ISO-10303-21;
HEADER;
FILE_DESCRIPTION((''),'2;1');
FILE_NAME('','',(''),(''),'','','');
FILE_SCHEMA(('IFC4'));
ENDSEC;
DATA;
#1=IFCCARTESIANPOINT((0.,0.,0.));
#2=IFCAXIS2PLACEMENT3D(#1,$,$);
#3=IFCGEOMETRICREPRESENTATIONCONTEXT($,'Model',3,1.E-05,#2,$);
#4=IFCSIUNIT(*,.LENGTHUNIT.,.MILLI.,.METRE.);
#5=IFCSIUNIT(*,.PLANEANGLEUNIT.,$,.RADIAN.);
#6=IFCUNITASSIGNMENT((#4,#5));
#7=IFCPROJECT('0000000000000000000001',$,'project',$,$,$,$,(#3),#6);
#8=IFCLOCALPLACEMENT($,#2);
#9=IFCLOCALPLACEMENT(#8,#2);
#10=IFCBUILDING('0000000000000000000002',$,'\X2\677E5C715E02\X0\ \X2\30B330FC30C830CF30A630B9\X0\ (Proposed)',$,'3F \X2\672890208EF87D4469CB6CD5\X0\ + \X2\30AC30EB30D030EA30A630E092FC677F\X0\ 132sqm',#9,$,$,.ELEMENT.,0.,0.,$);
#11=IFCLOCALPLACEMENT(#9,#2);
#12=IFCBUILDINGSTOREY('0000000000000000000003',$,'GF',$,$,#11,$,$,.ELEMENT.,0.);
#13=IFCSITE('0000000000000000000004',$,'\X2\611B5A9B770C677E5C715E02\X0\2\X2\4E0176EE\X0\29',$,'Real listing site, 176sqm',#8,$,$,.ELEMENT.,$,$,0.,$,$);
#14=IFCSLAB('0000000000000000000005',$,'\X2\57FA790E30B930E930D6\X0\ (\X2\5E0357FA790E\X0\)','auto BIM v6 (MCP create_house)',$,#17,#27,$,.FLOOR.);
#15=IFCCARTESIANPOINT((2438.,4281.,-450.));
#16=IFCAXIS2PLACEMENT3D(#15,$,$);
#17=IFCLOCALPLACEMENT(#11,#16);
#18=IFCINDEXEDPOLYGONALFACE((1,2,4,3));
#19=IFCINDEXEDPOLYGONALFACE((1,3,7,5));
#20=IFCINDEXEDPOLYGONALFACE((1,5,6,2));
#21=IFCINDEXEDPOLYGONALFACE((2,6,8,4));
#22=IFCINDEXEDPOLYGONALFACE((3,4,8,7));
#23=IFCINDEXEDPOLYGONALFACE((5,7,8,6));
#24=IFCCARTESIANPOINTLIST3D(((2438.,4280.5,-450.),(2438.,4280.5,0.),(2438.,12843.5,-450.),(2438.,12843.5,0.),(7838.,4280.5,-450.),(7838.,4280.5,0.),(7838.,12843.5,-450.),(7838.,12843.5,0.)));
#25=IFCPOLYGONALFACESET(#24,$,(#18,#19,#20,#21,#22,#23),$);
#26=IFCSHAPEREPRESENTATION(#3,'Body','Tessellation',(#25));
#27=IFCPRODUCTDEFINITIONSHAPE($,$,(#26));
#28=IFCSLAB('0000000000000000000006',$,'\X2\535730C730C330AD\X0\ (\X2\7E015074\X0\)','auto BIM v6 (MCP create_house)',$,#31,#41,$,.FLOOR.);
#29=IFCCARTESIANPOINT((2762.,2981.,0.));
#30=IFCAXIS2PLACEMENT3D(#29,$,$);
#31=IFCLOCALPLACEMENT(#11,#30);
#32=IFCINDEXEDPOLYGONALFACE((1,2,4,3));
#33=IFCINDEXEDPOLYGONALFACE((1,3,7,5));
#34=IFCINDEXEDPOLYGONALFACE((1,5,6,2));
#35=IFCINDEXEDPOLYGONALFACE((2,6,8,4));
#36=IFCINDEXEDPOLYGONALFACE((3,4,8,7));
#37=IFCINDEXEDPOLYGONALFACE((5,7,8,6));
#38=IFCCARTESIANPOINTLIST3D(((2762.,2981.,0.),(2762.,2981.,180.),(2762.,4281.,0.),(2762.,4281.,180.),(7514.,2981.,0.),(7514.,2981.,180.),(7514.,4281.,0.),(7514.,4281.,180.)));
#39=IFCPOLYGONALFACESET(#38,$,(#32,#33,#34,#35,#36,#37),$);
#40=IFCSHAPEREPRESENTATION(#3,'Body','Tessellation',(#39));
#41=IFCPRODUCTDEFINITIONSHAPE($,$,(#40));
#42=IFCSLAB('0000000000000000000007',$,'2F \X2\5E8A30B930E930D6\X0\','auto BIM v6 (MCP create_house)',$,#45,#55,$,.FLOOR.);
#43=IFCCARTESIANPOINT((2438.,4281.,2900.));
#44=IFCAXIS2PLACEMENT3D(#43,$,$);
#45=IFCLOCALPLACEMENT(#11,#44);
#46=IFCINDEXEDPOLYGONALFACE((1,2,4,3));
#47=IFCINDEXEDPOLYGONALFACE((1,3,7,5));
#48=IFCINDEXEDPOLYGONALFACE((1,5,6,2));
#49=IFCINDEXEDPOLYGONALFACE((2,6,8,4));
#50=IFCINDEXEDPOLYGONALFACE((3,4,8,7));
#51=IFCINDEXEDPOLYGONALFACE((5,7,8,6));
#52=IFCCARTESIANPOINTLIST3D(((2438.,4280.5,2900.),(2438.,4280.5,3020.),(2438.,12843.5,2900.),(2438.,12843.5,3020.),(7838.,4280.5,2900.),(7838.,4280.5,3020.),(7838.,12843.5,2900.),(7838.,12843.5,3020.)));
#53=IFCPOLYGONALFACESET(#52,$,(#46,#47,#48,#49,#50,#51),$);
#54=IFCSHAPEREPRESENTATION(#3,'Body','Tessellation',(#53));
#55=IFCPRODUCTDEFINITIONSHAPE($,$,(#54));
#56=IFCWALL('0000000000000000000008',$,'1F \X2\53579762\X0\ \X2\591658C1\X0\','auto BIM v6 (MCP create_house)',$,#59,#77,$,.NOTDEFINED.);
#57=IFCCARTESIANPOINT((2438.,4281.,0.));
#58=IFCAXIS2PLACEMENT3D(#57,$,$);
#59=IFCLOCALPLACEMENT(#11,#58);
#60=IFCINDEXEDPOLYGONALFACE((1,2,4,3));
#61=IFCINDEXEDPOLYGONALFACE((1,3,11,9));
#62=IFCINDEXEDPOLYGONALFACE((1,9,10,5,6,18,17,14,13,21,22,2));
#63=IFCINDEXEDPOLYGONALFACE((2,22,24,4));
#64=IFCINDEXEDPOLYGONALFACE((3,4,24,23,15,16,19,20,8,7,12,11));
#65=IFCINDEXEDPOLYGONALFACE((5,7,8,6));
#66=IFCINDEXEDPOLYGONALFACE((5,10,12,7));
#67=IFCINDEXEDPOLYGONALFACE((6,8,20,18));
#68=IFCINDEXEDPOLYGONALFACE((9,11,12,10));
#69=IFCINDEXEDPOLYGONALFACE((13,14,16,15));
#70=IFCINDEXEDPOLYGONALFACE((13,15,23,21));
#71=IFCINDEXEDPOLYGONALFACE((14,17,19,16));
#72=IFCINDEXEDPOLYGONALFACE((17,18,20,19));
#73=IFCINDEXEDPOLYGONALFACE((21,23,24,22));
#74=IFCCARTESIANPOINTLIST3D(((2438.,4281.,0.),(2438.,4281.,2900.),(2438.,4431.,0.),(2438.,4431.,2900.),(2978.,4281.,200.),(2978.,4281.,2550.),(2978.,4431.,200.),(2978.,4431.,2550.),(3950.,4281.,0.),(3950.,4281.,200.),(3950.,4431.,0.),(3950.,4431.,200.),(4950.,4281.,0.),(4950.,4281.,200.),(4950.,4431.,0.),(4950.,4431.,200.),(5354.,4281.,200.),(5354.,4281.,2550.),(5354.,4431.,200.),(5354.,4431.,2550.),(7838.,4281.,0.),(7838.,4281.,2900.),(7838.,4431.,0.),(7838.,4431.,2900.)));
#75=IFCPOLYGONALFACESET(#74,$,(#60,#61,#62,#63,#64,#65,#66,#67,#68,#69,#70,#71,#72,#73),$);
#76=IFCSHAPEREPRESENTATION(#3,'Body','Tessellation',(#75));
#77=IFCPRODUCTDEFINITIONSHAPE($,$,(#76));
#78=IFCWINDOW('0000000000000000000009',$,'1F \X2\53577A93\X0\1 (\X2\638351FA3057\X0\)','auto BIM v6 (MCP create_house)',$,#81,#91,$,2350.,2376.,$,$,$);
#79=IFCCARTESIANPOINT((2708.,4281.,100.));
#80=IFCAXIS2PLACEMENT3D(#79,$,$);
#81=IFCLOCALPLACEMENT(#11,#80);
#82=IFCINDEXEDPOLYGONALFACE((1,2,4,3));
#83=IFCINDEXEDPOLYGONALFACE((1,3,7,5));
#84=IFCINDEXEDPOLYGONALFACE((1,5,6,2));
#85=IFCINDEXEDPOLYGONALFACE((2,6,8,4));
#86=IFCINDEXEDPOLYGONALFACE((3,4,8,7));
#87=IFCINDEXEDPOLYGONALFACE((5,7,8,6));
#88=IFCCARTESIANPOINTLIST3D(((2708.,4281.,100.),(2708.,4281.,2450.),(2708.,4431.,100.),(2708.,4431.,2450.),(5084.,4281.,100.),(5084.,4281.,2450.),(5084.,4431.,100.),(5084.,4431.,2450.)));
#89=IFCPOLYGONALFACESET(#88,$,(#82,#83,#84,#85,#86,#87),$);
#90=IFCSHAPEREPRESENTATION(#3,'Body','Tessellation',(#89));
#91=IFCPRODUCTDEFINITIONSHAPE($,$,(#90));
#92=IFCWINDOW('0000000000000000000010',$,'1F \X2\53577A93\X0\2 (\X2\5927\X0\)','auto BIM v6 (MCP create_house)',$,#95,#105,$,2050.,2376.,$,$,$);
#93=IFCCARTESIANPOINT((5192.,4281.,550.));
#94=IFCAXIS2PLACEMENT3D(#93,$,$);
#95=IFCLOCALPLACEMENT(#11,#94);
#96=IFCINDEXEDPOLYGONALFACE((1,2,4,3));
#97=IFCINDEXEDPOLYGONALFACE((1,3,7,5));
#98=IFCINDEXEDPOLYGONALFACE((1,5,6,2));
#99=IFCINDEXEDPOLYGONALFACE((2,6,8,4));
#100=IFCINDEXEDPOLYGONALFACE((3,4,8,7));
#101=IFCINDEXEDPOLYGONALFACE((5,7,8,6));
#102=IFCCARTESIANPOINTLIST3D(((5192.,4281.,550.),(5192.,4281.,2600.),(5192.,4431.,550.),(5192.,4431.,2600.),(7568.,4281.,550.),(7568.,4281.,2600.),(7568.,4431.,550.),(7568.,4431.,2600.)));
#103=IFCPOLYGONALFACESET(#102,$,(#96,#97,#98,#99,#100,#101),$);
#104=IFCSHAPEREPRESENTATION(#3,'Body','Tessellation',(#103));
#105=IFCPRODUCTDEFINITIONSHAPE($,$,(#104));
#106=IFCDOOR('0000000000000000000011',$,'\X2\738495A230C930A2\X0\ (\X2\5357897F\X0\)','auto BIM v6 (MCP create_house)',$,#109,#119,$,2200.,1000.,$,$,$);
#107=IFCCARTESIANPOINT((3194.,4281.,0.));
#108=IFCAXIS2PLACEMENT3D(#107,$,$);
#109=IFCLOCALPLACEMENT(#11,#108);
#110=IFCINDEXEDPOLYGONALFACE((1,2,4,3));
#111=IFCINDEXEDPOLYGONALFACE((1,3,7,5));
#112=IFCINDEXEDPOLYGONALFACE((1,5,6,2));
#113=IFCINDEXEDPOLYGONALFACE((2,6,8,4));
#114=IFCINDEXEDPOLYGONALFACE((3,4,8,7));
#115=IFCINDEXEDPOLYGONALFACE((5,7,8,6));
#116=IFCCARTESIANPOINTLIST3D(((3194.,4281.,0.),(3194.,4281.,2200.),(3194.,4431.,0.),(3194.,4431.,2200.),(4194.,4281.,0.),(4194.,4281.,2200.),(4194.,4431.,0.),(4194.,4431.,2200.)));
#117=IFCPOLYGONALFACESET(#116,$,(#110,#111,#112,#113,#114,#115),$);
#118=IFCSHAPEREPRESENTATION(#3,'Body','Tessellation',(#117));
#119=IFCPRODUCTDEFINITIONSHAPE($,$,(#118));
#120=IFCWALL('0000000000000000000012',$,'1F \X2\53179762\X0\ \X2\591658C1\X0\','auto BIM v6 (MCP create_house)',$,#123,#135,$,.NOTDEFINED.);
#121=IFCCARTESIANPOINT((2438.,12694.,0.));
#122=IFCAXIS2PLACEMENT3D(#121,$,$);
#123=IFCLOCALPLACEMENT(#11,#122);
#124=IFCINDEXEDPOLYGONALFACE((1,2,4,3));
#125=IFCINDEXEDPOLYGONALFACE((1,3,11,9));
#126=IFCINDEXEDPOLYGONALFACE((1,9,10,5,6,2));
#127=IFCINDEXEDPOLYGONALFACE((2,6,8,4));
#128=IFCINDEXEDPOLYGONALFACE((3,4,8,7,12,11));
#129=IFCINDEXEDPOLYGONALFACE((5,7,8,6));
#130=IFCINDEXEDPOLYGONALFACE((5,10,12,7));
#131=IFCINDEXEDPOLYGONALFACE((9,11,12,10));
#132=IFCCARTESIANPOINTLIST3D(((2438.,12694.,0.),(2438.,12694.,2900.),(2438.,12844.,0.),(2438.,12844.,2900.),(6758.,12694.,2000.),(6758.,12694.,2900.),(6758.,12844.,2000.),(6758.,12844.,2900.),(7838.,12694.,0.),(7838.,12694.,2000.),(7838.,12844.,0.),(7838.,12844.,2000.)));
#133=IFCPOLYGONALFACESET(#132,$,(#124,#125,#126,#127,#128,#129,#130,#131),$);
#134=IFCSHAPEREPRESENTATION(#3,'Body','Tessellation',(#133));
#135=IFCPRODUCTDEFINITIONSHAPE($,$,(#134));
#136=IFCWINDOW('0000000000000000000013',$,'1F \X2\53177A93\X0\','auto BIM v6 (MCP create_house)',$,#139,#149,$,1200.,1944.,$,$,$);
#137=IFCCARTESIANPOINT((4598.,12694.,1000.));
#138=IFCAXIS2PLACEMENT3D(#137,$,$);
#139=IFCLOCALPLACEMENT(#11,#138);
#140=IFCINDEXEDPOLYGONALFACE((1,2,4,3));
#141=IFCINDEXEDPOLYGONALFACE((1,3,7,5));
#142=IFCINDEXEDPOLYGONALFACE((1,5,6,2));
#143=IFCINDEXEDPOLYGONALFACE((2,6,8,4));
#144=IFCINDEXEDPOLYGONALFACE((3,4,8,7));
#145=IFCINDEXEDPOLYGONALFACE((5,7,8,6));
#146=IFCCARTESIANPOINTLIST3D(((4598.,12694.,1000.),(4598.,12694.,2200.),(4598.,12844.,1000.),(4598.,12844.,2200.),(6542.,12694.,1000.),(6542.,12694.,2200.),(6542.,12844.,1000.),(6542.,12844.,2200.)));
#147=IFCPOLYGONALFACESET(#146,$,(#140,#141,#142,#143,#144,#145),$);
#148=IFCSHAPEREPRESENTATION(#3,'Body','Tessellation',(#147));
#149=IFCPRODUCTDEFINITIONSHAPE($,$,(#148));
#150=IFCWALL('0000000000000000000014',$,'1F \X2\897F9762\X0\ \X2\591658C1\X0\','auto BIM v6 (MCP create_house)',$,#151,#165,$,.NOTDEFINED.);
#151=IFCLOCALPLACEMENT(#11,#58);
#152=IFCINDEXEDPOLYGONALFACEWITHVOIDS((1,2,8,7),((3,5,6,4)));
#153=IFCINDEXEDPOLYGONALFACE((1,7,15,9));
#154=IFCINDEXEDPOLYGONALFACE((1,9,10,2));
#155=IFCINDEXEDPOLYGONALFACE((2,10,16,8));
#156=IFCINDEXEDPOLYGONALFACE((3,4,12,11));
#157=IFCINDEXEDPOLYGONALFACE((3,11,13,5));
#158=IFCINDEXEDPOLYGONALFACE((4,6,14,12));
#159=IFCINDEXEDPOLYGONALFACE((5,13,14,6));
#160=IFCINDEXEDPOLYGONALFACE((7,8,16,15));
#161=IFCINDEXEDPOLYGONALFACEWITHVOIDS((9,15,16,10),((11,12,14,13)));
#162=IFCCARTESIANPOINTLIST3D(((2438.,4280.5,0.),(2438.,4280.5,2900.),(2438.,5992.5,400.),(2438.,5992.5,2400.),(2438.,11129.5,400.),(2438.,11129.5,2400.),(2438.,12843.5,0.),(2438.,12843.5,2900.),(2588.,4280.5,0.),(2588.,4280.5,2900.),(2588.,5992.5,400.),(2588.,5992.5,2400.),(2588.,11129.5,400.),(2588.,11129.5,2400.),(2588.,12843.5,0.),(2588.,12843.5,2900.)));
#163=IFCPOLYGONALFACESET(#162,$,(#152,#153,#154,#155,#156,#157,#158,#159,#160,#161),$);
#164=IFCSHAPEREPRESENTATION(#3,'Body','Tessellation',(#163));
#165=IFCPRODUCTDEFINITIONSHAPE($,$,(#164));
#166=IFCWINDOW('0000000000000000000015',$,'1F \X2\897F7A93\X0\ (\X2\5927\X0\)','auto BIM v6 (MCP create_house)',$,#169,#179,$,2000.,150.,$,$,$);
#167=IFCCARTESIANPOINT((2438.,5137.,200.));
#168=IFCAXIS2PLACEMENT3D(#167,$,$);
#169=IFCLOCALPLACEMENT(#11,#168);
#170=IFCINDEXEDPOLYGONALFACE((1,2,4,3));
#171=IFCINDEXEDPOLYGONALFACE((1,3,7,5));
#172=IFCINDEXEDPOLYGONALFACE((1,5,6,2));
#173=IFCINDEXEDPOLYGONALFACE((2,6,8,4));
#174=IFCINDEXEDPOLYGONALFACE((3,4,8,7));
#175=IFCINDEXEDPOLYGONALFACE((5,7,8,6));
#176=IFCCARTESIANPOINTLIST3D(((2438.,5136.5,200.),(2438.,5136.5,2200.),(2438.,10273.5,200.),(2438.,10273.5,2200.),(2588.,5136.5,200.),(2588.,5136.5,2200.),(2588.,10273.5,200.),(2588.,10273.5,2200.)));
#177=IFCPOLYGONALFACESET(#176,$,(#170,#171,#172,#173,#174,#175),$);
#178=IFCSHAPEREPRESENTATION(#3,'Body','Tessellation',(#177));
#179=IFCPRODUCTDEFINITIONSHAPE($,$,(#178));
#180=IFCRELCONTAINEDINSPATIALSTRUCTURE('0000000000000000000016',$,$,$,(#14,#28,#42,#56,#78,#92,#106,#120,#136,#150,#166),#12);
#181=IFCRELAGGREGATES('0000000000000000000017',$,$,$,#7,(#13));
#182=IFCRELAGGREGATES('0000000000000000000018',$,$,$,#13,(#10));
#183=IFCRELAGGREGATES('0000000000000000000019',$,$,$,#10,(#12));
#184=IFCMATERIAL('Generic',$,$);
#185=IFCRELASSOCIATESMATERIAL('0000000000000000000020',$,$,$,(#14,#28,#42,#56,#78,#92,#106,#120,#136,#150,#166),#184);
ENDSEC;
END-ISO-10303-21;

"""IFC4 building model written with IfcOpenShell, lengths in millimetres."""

from ifc_helpers import new_model, si_unit, frame, frame_2d, origin, place, context, project, spatial, rectangle, extrude, material, element, fill, save


model = new_model("IFC4")

# Units and contexts
model_context = context("Model", 3, precision=1e-05, world=origin())
ifc_project = project(units=[si_unit("LENGTHUNIT", "METRE", prefix="MILLI"), si_unit("PLANEANGLEUNIT", "RADIAN")], contexts=[model_context])

# Site, building, storey
site_placement = place(None, origin())
site = spatial("IfcSite", under=ifc_project, at=site_placement, Name="愛媛県松山市2丁目29", ObjectType="Real listing site, 176sqm", CompositionType="ELEMENT", RefElevation=0.0)
building_placement = place(site_placement, origin())
building = spatial("IfcBuilding", under=site, at=building_placement, Name="松山市 コートハウス (Proposed)", ObjectType="3F 木造軸組構法 + ガルバリウム鋼板 132sqm", CompositionType="ELEMENT", ElevationOfRefHeight=0.0, ElevationOfTerrain=0.0)
storey_placement = place(building_placement, origin())
storey = spatial("IfcBuildingStorey", under=building, at=storey_placement, Name="GF", CompositionType="ELEMENT", Elevation=0.0)

# Slabs
ifc_material = material(Name="Generic")
slab_1_placement = place(storey_placement, frame((2438.0, 4281.0, -450.0)))
element("IfcSlab", 1, at=slab_1_placement, inside=storey, material=ifc_material, Name="基礎スラブ (布基礎)", Description="auto BIM v6 (MCP create_house)", PredefinedType="FLOOR", context=model_context, shape_type="SweptSolid", body=[
    extrude(rectangle(XDim=5400.0, YDim=8563.0, at=frame_2d((2700.0, 4281.0))), frame((2438.0, 4281.0, -450.0)), (0.0, 0.0, 1.0), 450.0),
])
slab_2_placement = place(storey_placement, frame((2762.0, 2981.0, 0.0)))
element("IfcSlab", 2, at=slab_2_placement, inside=storey, material=ifc_material, Name="南デッキ (縁側)", Description="auto BIM v6 (MCP create_house)", PredefinedType="FLOOR", context=model_context, shape_type="SweptSolid", body=[
    extrude(rectangle(XDim=4752.0, YDim=1300.0, at=frame_2d((2376.0, 650.0))), frame((2762.0, 2981.0, 0.0)), (0.0, 0.0, 1.0), 180.0),
])
slab_3_placement = place(storey_placement, frame((2438.0, 4281.0, 2900.0)))
element("IfcSlab", 3, at=slab_3_placement, inside=storey, material=ifc_material, Name="2F 床スラブ", Description="auto BIM v6 (MCP create_house)", PredefinedType="FLOOR", context=model_context, shape_type="SweptSolid", body=[
    extrude(rectangle(XDim=5400.0, YDim=8563.0, at=frame_2d((2700.0, 4281.0))), frame((2438.0, 4281.0, 2900.0)), (0.0, 0.0, 1.0), 120.0),
])

# Wall, openings, windows, door
wall_1_placement = place(storey_placement, frame((2438.0, 4281.0, 0.0)))
wall_1 = element("IfcWall", 4, at=wall_1_placement, inside=storey, material=ifc_material, Name="1F 南面 外壁", Description="auto BIM v6 (MCP create_house)", PredefinedType="NOTDEFINED", context=model_context, shape_type="SweptSolid", body=[
    extrude(rectangle(XDim=5400.0, YDim=150.0, at=frame_2d((2700.0, 75.0))), frame((2438.0, 4281.0, 0.0)), (0.0, 0.0, 1.0), 2900.0),
])
opening_1_placement = place(storey_placement, frame((2708.0, 4281.0, 100.0)))
opening_1 = element("IfcOpeningElement", 5, at=opening_1_placement, cuts=wall_1, PredefinedType="NOTDEFINED", context=model_context, shape_type="SweptSolid", body=[
    extrude(rectangle(XDim=2376.0, YDim=150.0, at=frame_2d((1188.0, 75.0))), frame((2708.0, 4281.0, 100.0)), (0.0, 0.0, 1.0), 2350.0),
])
opening_2_placement = place(storey_placement, frame((5192.0, 4281.0, 550.0)))
opening_2 = element("IfcOpeningElement", 6, at=opening_2_placement, cuts=wall_1, PredefinedType="NOTDEFINED", context=model_context, shape_type="SweptSolid", body=[
    extrude(rectangle(XDim=2376.0, YDim=150.0, at=frame_2d((1188.0, 75.0))), frame((5192.0, 4281.0, 550.0)), (0.0, 0.0, 1.0), 2050.0),
])
opening_3_placement = place(storey_placement, frame((3194.0, 4281.0, 0.0)))
opening_3 = element("IfcOpeningElement", 7, at=opening_3_placement, cuts=wall_1, PredefinedType="NOTDEFINED", context=model_context, shape_type="SweptSolid", body=[
    extrude(rectangle(XDim=1000.0, YDim=150.0, at=frame_2d((500.0, 75.0))), frame((3194.0, 4281.0, 0.0)), (0.0, 0.0, 1.0), 2200.0),
])
window_1_placement = place(storey_placement, frame((2708.0, 4281.0, 100.0)))
window_1 = element("IfcWindow", 8, at=window_1_placement, inside=storey, material=ifc_material, Name="1F 南窓1 (掃出し)", Description="auto BIM v6 (MCP create_house)", OverallHeight=2350.0, OverallWidth=2376.0, context=model_context, shape_type="SweptSolid", body=[
    extrude(rectangle(XDim=2376.0, YDim=150.0, at=frame_2d((1188.0, 75.0))), frame((2708.0, 4281.0, 100.0)), (0.0, 0.0, 1.0), 2350.0),
])
fill(opening_1, window_1)
window_2_placement = place(storey_placement, frame((5192.0, 4281.0, 550.0)))
window_2 = element("IfcWindow", 9, at=window_2_placement, inside=storey, material=ifc_material, Name="1F 南窓2 (大)", Description="auto BIM v6 (MCP create_house)", OverallHeight=2050.0, OverallWidth=2376.0, context=model_context, shape_type="SweptSolid", body=[
    extrude(rectangle(XDim=2376.0, YDim=150.0, at=frame_2d((1188.0, 75.0))), frame((5192.0, 4281.0, 550.0)), (0.0, 0.0, 1.0), 2050.0),
])
fill(opening_2, window_2)
door_placement = place(storey_placement, frame((3194.0, 4281.0, 0.0)))
door = element("IfcDoor", 10, at=door_placement, inside=storey, material=ifc_material, Name="玄関ドア (南西)", Description="auto BIM v6 (MCP create_house)", OverallHeight=2200.0, OverallWidth=1000.0, context=model_context, shape_type="SweptSolid", body=[
    extrude(rectangle(XDim=1000.0, YDim=150.0, at=frame_2d((500.0, 75.0))), frame((3194.0, 4281.0, 0.0)), (0.0, 0.0, 1.0), 2200.0),
])
fill(opening_3, door)

# Walls, openings, windows
wall_2_placement = place(storey_placement, frame((2438.0, 12694.0, 0.0)))
wall_2 = element("IfcWall", 11, at=wall_2_placement, inside=storey, material=ifc_material, Name="1F 北面 外壁", Description="auto BIM v6 (MCP create_house)", PredefinedType="NOTDEFINED", context=model_context, shape_type="SweptSolid", body=[
    extrude(rectangle(XDim=5400.0, YDim=150.0, at=frame_2d((2700.0, 75.0))), frame((2438.0, 12694.0, 0.0)), (0.0, 0.0, 1.0), 2900.0),
])
opening_4_placement = place(storey_placement, frame((4598.0, 12694.0, 1000.0)))
opening_4 = element("IfcOpeningElement", 12, at=opening_4_placement, cuts=wall_2, PredefinedType="NOTDEFINED", context=model_context, shape_type="SweptSolid", body=[
    extrude(rectangle(XDim=1944.0, YDim=150.0, at=frame_2d((972.0, 75.0))), frame((4598.0, 12694.0, 1000.0)), (0.0, 0.0, 1.0), 1200.0),
])
window_3_placement = place(storey_placement, frame((4598.0, 12694.0, 1000.0)))
window_3 = element("IfcWindow", 13, at=window_3_placement, inside=storey, material=ifc_material, Name="1F 北窓", Description="auto BIM v6 (MCP create_house)", OverallHeight=1200.0, OverallWidth=1944.0, context=model_context, shape_type="SweptSolid", body=[
    extrude(rectangle(XDim=1944.0, YDim=150.0, at=frame_2d((972.0, 75.0))), frame((4598.0, 12694.0, 1000.0)), (0.0, 0.0, 1.0), 1200.0),
])
fill(opening_4, window_3)
wall_3_placement = place(storey_placement, frame((2438.0, 4281.0, 0.0)))
wall_3 = element("IfcWall", 14, at=wall_3_placement, inside=storey, material=ifc_material, Name="1F 西面 外壁", Description="auto BIM v6 (MCP create_house)", PredefinedType="NOTDEFINED", context=model_context, shape_type="SweptSolid", body=[
    extrude(rectangle(XDim=150.0, YDim=8563.0, at=frame_2d((75.0, 4281.0))), frame((2438.0, 4281.0, 0.0)), (0.0, 0.0, 1.0), 2900.0),
])
opening_5_placement = place(storey_placement, frame((2438.0, 5137.0, 200.0)))
opening_5 = element("IfcOpeningElement", 15, at=opening_5_placement, cuts=wall_3, PredefinedType="NOTDEFINED", context=model_context, shape_type="SweptSolid", body=[
    extrude(rectangle(XDim=150.0, YDim=5137.0, at=frame_2d((75.0, 2568.0))), frame((2438.0, 5137.0, 200.0)), (0.0, 0.0, 1.0), 2000.0),
])
window_4_placement = place(storey_placement, frame((2438.0, 5137.0, 200.0)))
window_4 = element("IfcWindow", 16, at=window_4_placement, inside=storey, material=ifc_material, Name="1F 西窓 (大)", Description="auto BIM v6 (MCP create_house)", OverallHeight=2000.0, OverallWidth=150.0, context=model_context, shape_type="SweptSolid", body=[
    extrude(rectangle(XDim=150.0, YDim=5137.0, at=frame_2d((75.0, 2568.0))), frame((2438.0, 5137.0, 200.0)), (0.0, 0.0, 1.0), 2000.0),
])
fill(opening_5, window_4)

save(model, "model.ifc")
